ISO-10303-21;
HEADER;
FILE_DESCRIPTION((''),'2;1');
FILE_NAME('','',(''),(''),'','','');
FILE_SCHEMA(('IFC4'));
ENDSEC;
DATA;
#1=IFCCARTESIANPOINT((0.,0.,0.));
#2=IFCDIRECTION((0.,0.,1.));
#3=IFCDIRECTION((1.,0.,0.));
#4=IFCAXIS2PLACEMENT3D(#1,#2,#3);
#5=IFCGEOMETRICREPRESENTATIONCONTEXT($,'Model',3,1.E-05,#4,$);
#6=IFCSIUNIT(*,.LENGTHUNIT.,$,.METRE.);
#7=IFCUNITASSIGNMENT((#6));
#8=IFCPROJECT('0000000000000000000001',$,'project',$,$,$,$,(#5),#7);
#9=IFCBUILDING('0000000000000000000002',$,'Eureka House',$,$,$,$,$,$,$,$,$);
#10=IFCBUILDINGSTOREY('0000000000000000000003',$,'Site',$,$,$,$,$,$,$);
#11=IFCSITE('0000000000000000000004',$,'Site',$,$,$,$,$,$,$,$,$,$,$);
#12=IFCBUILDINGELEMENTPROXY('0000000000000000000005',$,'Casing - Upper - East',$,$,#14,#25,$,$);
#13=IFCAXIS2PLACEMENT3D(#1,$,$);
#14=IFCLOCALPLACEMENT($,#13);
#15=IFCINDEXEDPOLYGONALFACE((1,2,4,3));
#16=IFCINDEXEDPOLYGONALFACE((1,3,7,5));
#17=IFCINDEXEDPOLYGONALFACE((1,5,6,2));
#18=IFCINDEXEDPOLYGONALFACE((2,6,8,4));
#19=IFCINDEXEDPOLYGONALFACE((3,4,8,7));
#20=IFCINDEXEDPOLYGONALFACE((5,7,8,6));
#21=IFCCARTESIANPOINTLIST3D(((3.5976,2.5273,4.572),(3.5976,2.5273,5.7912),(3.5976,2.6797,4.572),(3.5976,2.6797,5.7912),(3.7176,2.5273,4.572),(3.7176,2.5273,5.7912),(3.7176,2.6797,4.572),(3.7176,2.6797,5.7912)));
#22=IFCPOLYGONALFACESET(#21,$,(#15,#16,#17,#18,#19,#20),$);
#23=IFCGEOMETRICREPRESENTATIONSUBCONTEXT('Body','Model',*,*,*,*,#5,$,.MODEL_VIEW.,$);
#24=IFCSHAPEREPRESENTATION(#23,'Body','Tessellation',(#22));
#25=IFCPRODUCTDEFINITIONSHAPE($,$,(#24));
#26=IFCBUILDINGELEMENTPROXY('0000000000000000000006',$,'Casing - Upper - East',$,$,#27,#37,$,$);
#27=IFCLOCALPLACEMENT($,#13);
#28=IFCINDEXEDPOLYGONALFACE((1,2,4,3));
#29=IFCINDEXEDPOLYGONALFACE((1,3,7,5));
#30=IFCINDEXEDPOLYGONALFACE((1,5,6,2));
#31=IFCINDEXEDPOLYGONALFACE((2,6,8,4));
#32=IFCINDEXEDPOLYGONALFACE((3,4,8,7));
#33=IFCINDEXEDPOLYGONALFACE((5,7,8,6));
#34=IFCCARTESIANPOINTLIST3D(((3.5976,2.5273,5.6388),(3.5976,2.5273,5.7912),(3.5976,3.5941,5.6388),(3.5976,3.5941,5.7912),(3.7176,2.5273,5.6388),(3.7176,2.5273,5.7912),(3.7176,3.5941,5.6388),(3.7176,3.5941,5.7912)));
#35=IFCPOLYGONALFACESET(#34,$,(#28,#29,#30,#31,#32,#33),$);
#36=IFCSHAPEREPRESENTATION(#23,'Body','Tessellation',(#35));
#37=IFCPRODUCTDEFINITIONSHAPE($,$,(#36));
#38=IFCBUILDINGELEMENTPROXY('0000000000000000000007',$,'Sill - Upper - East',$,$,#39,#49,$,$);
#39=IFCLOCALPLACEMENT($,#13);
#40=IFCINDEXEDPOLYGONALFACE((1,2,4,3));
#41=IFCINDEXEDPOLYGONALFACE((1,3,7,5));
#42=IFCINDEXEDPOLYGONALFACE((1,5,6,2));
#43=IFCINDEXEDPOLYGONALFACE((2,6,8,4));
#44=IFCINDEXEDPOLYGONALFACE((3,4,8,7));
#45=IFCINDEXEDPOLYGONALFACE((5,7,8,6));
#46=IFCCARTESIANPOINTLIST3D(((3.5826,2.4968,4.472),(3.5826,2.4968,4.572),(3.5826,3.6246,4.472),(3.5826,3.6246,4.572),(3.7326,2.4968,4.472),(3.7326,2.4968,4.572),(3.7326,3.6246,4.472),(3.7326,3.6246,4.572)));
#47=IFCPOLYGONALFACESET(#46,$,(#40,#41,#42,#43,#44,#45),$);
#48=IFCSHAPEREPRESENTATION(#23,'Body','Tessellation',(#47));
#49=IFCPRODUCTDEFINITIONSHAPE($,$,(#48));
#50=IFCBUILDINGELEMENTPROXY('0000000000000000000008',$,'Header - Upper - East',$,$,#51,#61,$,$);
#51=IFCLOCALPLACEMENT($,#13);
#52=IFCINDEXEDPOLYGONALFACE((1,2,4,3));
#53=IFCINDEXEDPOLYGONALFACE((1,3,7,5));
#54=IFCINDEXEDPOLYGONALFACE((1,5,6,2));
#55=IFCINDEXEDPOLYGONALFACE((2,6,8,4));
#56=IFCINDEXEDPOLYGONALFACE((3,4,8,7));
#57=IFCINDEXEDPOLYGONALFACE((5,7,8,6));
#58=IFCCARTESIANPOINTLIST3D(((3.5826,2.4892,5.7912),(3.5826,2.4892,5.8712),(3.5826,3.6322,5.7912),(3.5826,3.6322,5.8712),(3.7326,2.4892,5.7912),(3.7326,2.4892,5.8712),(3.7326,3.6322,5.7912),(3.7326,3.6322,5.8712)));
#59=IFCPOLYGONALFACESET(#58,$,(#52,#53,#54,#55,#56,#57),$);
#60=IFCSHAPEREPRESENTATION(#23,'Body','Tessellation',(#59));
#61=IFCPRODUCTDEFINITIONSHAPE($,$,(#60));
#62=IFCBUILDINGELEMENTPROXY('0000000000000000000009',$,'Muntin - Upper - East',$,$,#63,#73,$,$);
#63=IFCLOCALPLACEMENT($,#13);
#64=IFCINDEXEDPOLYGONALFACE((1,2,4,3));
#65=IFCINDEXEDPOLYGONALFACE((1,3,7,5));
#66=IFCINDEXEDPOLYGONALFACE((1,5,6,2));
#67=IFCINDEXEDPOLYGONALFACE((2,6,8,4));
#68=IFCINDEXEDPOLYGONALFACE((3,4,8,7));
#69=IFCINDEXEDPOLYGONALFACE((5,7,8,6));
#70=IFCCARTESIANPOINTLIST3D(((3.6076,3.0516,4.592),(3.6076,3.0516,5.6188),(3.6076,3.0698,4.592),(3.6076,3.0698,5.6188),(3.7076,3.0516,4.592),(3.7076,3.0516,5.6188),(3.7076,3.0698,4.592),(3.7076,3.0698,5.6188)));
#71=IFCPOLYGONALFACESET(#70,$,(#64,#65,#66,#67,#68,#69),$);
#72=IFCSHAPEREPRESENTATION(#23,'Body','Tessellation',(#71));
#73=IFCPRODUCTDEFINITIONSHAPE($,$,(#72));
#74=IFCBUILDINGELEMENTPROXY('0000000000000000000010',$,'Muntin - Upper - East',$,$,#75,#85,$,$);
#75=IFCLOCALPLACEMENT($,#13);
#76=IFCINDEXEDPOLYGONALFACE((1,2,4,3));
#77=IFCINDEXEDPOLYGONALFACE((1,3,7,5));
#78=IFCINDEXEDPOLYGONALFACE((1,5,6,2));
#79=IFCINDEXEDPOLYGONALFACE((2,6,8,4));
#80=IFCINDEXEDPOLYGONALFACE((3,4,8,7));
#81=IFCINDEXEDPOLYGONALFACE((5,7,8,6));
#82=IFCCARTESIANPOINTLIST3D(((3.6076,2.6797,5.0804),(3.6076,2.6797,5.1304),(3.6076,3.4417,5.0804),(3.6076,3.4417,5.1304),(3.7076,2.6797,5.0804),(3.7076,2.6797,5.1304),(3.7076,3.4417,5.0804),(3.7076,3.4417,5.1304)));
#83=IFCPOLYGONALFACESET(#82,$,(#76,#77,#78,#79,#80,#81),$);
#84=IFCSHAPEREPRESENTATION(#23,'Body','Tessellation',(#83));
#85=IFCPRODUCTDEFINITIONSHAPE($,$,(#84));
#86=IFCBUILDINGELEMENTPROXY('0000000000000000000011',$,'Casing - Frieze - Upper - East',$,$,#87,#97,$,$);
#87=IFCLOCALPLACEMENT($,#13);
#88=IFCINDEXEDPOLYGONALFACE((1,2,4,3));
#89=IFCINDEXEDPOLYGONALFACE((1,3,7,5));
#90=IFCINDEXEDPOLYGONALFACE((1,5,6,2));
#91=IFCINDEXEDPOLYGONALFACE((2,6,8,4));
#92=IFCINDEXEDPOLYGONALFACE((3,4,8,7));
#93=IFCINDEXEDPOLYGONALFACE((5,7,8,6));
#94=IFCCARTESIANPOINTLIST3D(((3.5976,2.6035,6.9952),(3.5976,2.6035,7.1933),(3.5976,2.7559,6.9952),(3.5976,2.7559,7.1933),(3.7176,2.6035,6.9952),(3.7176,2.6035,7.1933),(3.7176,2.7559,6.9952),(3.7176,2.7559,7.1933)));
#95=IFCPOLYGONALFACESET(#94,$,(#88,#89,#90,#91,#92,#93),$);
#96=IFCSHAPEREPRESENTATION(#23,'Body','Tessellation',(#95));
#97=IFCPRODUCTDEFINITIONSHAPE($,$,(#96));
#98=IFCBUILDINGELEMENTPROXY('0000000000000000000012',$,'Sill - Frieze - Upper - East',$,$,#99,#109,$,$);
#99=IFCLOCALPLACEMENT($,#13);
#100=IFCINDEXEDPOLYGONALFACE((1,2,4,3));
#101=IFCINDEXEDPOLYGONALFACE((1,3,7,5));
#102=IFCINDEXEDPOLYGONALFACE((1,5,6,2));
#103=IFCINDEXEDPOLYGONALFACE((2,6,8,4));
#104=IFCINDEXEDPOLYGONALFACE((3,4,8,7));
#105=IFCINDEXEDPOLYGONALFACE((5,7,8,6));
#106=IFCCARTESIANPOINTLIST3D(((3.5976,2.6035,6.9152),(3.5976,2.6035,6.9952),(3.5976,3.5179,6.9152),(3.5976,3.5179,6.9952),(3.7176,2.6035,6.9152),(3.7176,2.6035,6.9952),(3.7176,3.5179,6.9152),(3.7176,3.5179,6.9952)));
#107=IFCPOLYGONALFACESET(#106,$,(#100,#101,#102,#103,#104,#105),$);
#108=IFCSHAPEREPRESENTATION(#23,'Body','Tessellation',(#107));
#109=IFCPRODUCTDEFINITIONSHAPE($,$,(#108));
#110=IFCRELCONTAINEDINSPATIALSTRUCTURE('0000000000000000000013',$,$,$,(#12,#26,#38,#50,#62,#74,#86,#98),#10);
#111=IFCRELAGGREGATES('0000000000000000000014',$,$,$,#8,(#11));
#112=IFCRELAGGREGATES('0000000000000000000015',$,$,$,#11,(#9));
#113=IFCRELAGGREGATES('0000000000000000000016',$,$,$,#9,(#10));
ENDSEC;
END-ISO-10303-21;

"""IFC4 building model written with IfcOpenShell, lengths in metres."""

from ifc_helpers import new_model, si_unit, frame, origin, origin_with_axes, origin_2d, place, context, subcontext, project, spatial, rectangle, extrude, element, save


model = new_model("IFC4")

# Units and contexts
model_context = context("Model", 3, precision=1e-05, world=origin_with_axes())
body_context = subcontext(model_context, "Body", "Model", "MODEL_VIEW")
ifc_project = project(units=[si_unit("LENGTHUNIT", "METRE")], contexts=[model_context])

# Site, building, storey
site = spatial("IfcSite", under=ifc_project, Name="Site")
building = spatial("IfcBuilding", under=site, Name="Eureka House")
storey = spatial("IfcBuildingStorey", under=building, Name="Site")

# Building element proxies
proxy_1_placement = place(None, frame((3.6576, 2.6035, 4.572), z_axis=(0.0, 0.0, 1.0), x_axis=(1.0, 0.0, 0.0)))
element("IfcBuildingElementProxy", 1, at=proxy_1_placement, inside=storey, Name="Casing - Upper - East", context=body_context, shape_type="SweptSolid", body=[
    extrude(rectangle(XDim=0.12, YDim=0.1524, at=origin_2d()), origin(), (0.0, 0.0, 1.0), 1.2192),
])
proxy_2_placement = place(None, frame((3.6576, 3.0607, 5.6388), z_axis=(0.0, 0.0, 1.0), x_axis=(1.0, 0.0, 0.0)))
element("IfcBuildingElementProxy", 2, at=proxy_2_placement, inside=storey, Name="Casing - Upper - East", context=body_context, shape_type="SweptSolid", body=[
    extrude(rectangle(XDim=0.12, YDim=1.0668, at=origin_2d()), origin(), (0.0, 0.0, 1.0), 0.1524),
])
proxy_3_placement = place(None, frame((3.6576, 3.0607, 4.472), z_axis=(0.0, 0.0, 1.0), x_axis=(1.0, 0.0, 0.0)))
element("IfcBuildingElementProxy", 3, at=proxy_3_placement, inside=storey, Name="Sill - Upper - East", context=body_context, shape_type="SweptSolid", body=[
    extrude(rectangle(XDim=0.15, YDim=1.1278, at=origin_2d()), origin(), (0.0, 0.0, 1.0), 0.1),
])
proxy_4_placement = place(None, frame((3.6576, 3.0607, 5.7912), z_axis=(0.0, 0.0, 1.0), x_axis=(1.0, 0.0, 0.0)))
element("IfcBuildingElementProxy", 4, at=proxy_4_placement, inside=storey, Name="Header - Upper - East", context=body_context, shape_type="SweptSolid", body=[
    extrude(rectangle(XDim=0.15, YDim=1.143, at=origin_2d()), origin(), (0.0, 0.0, 1.0), 0.08),
])
proxy_5_placement = place(None, frame((3.6576, 3.0607, 4.592), z_axis=(0.0, 0.0, 1.0), x_axis=(1.0, 0.0, 0.0)))
element("IfcBuildingElementProxy", 5, at=proxy_5_placement, inside=storey, Name="Muntin - Upper - East", context=body_context, shape_type="SweptSolid", body=[
    extrude(rectangle(XDim=0.1, YDim=0.0183, at=origin_2d()), origin(), (0.0, 0.0, 1.0), 1.0268),
])
proxy_6_placement = place(None, frame((3.6576, 3.0607, 5.0804), z_axis=(0.0, 0.0, 1.0), x_axis=(1.0, 0.0, 0.0)))
element("IfcBuildingElementProxy", 6, at=proxy_6_placement, inside=storey, Name="Muntin - Upper - East", context=body_context, shape_type="SweptSolid", body=[
    extrude(rectangle(XDim=0.1, YDim=0.762, at=origin_2d()), origin(), (0.0, 0.0, 1.0), 0.05),
])
proxy_7_placement = place(None, frame((3.6576, 2.6797, 6.9952), z_axis=(0.0, 0.0, 1.0), x_axis=(1.0, 0.0, 0.0)))
element("IfcBuildingElementProxy", 7, at=proxy_7_placement, inside=storey, Name="Casing - Frieze - Upper - East", context=body_context, shape_type="SweptSolid", body=[
    extrude(rectangle(XDim=0.12, YDim=0.1524, at=origin_2d()), origin(), (0.0, 0.0, 1.0), 0.1981),
])
proxy_8_placement = place(None, frame((3.6576, 3.0607, 6.9152), z_axis=(0.0, 0.0, 1.0), x_axis=(1.0, 0.0, 0.0)))
element("IfcBuildingElementProxy", 8, at=proxy_8_placement, inside=storey, Name="Sill - Frieze - Upper - East", context=body_context, shape_type="SweptSolid", body=[
    extrude(rectangle(XDim=0.12, YDim=0.9144, at=origin_2d()), origin(), (0.0, 0.0, 1.0), 0.08),
])

save(model, "model.ifc")
